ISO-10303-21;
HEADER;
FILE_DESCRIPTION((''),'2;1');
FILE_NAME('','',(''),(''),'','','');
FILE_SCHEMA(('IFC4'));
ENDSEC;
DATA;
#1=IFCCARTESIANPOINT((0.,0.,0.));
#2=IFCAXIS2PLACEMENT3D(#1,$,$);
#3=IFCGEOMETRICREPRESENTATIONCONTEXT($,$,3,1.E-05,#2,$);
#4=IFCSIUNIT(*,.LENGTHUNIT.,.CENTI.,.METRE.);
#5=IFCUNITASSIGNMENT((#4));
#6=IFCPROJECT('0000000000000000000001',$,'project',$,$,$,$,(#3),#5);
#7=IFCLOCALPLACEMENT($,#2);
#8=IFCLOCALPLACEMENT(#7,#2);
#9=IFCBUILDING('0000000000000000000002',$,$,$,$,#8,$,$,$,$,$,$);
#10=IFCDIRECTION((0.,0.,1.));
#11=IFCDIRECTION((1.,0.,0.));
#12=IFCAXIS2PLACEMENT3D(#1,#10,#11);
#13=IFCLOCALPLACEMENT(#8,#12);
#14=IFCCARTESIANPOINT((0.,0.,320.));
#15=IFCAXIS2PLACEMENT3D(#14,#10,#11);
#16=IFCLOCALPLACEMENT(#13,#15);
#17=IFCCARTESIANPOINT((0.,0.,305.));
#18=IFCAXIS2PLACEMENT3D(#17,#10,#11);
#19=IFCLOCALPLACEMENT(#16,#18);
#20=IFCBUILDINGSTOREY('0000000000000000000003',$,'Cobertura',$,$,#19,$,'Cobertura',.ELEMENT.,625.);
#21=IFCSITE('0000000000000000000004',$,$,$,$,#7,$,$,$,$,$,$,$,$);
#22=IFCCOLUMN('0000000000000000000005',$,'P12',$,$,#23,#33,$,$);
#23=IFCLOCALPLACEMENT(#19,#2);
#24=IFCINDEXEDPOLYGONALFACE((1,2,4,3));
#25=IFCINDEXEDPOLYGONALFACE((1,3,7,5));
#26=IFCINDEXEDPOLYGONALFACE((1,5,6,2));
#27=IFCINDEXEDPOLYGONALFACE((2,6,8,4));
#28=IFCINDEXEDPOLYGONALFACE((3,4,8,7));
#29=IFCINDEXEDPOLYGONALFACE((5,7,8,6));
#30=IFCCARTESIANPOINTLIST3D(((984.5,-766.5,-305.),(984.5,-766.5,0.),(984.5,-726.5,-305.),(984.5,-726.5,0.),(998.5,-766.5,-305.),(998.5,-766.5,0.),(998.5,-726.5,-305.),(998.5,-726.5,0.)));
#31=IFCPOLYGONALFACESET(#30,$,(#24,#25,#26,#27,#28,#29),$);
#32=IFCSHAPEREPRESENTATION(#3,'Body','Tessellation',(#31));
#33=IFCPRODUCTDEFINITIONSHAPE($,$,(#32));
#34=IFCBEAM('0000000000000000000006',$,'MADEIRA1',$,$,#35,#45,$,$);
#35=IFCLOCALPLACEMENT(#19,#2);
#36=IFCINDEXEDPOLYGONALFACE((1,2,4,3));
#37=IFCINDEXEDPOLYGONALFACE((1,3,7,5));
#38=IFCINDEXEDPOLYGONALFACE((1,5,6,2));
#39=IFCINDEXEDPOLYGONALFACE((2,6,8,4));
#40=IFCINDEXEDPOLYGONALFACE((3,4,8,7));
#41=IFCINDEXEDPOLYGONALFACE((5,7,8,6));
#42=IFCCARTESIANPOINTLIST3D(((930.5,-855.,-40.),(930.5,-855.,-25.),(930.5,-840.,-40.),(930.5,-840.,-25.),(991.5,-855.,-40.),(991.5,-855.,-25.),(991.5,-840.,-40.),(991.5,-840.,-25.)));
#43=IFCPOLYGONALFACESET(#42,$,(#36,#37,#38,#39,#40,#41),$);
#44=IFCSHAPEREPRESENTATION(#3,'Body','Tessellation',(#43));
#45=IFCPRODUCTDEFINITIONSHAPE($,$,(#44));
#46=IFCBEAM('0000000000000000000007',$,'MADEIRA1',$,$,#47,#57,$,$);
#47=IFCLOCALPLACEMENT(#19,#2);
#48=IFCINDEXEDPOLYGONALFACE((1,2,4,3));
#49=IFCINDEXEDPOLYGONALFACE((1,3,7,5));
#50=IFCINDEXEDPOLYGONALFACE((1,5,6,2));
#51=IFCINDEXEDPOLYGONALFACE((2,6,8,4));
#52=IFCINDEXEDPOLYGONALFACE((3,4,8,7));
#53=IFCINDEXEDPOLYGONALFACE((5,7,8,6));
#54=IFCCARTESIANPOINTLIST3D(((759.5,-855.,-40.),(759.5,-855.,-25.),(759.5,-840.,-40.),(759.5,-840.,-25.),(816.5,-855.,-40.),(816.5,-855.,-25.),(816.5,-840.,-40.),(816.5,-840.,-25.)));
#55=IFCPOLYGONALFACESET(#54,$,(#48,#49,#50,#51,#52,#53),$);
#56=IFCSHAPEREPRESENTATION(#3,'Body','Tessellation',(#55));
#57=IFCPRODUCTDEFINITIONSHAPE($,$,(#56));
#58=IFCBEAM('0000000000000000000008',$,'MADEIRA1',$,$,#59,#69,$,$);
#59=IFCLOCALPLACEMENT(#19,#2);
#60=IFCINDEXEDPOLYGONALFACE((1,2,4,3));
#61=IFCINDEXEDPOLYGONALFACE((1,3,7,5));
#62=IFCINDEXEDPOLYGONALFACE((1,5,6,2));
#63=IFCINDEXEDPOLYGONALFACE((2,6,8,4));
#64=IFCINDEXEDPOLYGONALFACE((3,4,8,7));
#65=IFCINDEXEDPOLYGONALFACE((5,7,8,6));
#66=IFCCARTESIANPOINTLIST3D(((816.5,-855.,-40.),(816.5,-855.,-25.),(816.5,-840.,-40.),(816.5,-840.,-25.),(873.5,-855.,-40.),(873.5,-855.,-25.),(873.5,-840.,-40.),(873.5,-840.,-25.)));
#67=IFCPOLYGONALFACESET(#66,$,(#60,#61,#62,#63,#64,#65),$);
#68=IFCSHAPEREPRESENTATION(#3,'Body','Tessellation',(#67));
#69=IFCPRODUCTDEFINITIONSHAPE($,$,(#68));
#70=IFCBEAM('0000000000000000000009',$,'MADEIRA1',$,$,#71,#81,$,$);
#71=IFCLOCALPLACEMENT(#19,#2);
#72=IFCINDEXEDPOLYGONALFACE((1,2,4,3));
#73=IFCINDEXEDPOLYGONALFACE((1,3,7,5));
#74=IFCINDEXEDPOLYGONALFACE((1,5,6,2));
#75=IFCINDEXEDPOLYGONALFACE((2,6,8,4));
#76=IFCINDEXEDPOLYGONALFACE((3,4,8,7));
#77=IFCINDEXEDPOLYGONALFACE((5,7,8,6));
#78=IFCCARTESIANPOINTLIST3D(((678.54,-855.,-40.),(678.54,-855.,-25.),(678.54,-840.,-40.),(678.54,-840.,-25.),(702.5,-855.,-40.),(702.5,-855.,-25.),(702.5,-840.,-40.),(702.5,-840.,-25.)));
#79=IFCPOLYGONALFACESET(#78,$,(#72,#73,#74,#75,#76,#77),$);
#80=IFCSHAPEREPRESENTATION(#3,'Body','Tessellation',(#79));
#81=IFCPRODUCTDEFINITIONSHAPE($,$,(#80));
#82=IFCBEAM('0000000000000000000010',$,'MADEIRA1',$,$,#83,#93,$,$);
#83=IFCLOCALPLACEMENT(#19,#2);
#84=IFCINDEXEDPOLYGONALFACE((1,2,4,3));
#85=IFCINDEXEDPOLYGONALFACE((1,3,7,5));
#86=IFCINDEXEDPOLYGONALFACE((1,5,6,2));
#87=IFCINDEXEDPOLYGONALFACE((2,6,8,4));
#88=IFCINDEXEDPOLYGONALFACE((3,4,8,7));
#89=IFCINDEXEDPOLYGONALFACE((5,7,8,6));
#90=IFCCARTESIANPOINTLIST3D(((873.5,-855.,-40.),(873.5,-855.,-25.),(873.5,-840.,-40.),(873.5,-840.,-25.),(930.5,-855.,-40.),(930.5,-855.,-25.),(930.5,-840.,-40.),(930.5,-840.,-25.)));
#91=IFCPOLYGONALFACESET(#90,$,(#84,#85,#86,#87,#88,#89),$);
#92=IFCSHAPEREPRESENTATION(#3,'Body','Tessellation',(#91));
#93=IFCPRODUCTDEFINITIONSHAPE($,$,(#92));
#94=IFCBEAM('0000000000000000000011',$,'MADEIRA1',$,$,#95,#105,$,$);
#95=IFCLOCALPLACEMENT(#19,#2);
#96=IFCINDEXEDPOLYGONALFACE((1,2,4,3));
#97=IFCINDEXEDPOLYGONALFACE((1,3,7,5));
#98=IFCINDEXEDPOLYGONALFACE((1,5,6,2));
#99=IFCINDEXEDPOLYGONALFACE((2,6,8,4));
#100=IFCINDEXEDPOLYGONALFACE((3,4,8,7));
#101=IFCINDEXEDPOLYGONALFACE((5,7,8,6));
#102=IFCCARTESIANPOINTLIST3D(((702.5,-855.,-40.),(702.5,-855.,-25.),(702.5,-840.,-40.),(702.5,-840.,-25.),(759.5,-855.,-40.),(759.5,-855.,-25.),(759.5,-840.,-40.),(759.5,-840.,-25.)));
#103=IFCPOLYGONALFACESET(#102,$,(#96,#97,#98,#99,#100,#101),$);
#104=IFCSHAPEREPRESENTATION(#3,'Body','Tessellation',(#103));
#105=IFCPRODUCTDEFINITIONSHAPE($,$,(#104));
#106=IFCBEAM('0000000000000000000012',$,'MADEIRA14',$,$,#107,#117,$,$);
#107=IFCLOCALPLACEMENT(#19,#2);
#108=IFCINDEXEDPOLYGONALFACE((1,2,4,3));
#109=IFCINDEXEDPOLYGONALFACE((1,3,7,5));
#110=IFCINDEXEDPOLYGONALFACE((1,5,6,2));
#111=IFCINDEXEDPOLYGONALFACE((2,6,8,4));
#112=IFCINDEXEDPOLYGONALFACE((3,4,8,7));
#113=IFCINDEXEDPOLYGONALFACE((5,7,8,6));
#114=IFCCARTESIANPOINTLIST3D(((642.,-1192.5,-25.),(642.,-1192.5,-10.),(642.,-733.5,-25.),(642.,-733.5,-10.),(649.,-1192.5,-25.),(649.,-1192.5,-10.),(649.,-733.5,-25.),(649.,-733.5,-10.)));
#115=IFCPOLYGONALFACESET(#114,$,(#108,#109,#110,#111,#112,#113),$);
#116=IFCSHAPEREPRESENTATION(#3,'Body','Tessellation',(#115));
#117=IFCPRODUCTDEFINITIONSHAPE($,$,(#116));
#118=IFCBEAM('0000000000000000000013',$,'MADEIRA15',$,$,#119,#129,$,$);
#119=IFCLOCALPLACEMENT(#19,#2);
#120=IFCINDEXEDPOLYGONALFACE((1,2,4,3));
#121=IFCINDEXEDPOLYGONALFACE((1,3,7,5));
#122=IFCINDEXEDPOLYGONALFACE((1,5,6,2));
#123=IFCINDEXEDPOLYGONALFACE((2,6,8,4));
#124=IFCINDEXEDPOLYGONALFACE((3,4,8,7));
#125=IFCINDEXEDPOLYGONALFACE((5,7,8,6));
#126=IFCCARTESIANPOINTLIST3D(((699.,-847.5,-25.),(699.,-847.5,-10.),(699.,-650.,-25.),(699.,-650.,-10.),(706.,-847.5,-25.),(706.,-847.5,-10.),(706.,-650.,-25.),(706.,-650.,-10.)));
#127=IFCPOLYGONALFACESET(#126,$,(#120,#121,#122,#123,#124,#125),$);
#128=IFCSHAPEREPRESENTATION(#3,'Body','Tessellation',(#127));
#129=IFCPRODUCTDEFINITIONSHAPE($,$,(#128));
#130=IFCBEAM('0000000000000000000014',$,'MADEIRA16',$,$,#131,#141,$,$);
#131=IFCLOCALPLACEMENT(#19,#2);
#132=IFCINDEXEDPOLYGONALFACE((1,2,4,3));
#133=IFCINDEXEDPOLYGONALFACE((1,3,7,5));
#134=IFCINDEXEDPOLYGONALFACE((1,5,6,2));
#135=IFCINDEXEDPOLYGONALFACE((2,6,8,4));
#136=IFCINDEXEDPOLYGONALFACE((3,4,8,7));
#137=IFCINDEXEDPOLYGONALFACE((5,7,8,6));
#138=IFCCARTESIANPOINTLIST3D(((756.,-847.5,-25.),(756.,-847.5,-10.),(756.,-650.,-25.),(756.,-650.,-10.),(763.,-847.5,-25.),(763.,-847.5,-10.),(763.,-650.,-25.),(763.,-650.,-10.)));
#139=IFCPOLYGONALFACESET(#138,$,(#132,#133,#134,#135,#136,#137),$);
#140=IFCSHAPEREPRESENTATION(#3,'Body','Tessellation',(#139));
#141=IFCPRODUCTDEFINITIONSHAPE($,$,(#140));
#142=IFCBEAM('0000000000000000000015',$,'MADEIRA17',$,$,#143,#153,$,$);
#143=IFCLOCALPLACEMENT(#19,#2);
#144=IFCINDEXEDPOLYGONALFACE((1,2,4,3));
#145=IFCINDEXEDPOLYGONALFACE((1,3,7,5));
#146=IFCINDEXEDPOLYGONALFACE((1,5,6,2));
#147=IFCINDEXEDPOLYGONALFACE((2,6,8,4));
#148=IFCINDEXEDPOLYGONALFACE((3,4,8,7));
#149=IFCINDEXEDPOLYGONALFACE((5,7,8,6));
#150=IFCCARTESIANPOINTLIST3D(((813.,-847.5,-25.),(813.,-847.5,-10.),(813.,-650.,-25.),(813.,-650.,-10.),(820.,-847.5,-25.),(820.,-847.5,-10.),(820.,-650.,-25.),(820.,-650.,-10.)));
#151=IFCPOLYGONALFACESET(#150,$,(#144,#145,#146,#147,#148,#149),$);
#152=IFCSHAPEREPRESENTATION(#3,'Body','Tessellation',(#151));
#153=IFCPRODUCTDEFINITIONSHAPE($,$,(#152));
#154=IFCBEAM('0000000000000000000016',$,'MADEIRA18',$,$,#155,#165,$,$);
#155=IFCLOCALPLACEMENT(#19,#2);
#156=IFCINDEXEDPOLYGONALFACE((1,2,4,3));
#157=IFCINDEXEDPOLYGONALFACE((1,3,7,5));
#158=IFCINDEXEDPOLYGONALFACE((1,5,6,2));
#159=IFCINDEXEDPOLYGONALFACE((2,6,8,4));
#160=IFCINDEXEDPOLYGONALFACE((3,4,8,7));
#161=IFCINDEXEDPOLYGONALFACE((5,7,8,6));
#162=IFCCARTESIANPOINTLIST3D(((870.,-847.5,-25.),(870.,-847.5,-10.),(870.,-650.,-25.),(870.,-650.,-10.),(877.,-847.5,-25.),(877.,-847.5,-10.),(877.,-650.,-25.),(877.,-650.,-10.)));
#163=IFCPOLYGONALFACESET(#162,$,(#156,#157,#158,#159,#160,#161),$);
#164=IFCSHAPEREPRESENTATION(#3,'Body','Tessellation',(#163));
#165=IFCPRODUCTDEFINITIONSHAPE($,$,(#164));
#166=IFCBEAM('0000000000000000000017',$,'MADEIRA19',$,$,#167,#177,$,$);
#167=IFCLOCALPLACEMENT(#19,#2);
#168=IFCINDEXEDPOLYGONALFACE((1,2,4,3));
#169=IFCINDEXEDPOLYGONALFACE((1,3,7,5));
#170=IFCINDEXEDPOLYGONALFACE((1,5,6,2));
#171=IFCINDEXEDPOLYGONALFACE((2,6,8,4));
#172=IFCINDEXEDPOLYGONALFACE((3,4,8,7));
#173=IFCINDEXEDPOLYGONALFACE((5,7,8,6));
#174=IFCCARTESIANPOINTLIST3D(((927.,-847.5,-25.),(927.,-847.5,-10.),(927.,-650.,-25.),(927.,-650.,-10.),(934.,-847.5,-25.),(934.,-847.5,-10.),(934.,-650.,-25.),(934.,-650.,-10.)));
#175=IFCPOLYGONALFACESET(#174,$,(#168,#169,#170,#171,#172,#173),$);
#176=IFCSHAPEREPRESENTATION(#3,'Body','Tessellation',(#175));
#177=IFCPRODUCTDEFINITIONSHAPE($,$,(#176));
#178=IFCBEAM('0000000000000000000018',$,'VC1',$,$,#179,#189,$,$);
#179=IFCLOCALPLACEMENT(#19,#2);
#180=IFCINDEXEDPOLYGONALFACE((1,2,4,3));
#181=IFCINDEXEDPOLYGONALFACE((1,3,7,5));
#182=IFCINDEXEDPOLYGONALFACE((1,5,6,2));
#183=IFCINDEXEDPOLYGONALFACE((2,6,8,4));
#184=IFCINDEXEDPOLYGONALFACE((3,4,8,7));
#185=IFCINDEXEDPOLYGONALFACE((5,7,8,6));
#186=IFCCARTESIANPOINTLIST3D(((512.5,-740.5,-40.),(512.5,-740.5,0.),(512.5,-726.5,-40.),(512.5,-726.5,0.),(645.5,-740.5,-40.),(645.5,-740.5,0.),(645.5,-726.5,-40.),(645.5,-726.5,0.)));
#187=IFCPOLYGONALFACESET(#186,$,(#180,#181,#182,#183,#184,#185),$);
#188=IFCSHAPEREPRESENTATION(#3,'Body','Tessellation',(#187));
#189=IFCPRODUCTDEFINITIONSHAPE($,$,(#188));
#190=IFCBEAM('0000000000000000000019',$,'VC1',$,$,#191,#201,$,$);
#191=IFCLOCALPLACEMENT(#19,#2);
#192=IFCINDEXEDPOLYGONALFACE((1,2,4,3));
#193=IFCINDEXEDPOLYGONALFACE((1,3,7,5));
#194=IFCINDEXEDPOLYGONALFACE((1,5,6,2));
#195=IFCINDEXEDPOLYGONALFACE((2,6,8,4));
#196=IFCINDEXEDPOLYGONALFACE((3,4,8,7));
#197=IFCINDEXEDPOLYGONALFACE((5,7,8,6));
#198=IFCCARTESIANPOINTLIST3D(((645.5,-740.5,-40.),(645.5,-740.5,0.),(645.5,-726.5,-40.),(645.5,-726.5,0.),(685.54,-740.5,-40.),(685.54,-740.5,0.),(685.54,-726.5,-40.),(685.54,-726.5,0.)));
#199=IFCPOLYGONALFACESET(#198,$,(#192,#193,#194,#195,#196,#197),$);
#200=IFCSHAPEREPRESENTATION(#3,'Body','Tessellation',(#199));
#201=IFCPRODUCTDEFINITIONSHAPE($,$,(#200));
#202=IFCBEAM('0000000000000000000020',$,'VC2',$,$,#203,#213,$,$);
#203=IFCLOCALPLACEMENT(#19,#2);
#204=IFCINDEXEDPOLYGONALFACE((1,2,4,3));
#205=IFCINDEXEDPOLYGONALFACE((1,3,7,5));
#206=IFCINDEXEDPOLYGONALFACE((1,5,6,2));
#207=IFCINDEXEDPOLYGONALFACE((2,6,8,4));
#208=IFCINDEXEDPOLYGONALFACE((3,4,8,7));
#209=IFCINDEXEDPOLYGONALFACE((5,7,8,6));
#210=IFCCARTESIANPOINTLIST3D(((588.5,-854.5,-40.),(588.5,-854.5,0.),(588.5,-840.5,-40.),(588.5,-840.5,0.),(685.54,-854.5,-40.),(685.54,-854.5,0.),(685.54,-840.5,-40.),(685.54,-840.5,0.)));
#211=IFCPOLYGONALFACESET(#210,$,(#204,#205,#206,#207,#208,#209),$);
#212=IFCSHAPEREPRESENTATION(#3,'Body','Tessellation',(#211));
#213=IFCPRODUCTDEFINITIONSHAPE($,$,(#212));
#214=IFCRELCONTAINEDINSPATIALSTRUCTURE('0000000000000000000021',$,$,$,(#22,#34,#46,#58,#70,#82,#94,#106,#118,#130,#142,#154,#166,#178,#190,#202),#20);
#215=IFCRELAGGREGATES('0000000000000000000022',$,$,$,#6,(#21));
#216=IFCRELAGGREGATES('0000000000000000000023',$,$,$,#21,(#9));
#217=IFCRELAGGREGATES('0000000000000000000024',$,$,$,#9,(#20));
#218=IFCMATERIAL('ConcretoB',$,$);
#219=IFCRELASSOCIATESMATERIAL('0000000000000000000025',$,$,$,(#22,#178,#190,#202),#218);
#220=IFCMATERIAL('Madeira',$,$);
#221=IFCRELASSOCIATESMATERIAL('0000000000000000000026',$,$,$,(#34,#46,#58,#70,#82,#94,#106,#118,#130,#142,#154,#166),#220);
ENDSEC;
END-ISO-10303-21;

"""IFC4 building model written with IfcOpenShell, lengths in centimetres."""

from ifc_helpers import new_model, si_unit, frame, origin, origin_with_axes, place, context, project, spatial, polyline, outline, extrude, material, element, save


model = new_model("IFC4")

# Units and contexts
context_of_model = context(None, 3, precision=1e-05, world=origin())
ifc_project = project(units=[si_unit("LENGTHUNIT", "METRE", prefix="CENTI")], contexts=[context_of_model])

# Site, building, storey
site_placement = place(None, origin())
site = spatial("IfcSite", under=ifc_project, at=site_placement)
building_placement = place(site_placement, origin())
building = spatial("IfcBuilding", under=site, at=building_placement)
placement_1 = place(building_placement, origin_with_axes())
placement_2 = place(placement_1, frame((0.0, 0.0, 320.0), z_axis=(0.0, 0.0, 1.0), x_axis=(1.0, 0.0, 0.0)))
storey_placement = place(placement_2, frame((0.0, 0.0, 305.0), z_axis=(0.0, 0.0, 1.0), x_axis=(1.0, 0.0, 0.0)))
storey = spatial("IfcBuildingStorey", under=building, at=storey_placement, Name="Cobertura", LongName="Cobertura", CompositionType="ELEMENT", Elevation=625.0)

# Column
ifc_material_1 = material(Name="ConcretoB")
column_placement = place(storey_placement, frame((991.5, -746.5, 0.0), z_axis=(0.0, 0.0, 1.0), x_axis=(1.0, 0.0, 0.0)))
element("IfcColumn", 1, at=column_placement, inside=storey, material=ifc_material_1, Name="P12", context=context_of_model, shape_type="SolidModel", body=[
    extrude(outline(polyline([(-7.0, -20.0), (7.0, -20.0), (7.0, 20.0), (-7.0, 20.0), (-7.0, -20.0)])), origin_with_axes(), (0.0, 0.0, -1.0), 305.0),
])

# Beams
ifc_material_2 = material(Name="Madeira")
beam_1_placement = place(storey_placement, frame((961.0, -847.5, -25.0), z_axis=(0.0, 0.0, 1.0), x_axis=(1.0, 0.0, 0.0)))
element("IfcBeam", 2, at=beam_1_placement, inside=storey, material=ifc_material_2, Name="MADEIRA1", context=context_of_model, shape_type="SolidModel", body=[
    extrude(outline(polyline([(-7.5, -7.5), (-7.5, 7.5), (7.5, 7.5), (7.5, -7.5), (-7.5, -7.5)])), frame((-30.5, 0.0, -7.5), z_axis=(1.0, 0.0, 0.0), x_axis=(0.0, -1.0, 0.0)), (0.0, 0.0, 1.0), 61.0),
])
for number, where, z_axis, x_axis, name in (
    (3, (788.0, -847.5, -25.0), (0.0, 0.0, 1.0), (1.0, 0.0, 0.0), "MADEIRA1"),
    (4, (845.0, -847.5, -25.0), (0.0, 0.0, 1.0), (1.0, 0.0, 0.0), "MADEIRA1"),
):
    element("IfcBeam", number, at=place(storey_placement, frame(where, z_axis=z_axis, x_axis=x_axis)), inside=storey, material=ifc_material_2, Name=name, context=context_of_model, shape_type="SolidModel", body=[
        extrude(outline(polyline([(-7.5, -7.5), (-7.5, 7.5), (7.5, 7.5), (7.5, -7.5), (-7.5, -7.5)])), frame((-28.5, 0.0, -7.5), z_axis=(1.0, 0.0, 0.0), x_axis=(0.0, -1.0, 0.0)), (0.0, 0.0, 1.0), 57.0),
    ])
beam_2_placement = place(storey_placement, frame((690.52, -847.5, -25.0), z_axis=(0.0, 0.0, 1.0), x_axis=(1.0, 0.0, 0.0)))
element("IfcBeam", 5, at=beam_2_placement, inside=storey, material=ifc_material_2, Name="MADEIRA1", context=context_of_model, shape_type="SolidModel", body=[
    extrude(outline(polyline([(-7.5, -7.5), (-7.5, 7.5), (7.5, 7.5), (7.5, -7.5), (-7.5, -7.5)])), frame((-11.98, 0.0, -7.5), z_axis=(1.0, 0.0, 0.0), x_axis=(0.0, -1.0, 0.0)), (0.0, 0.0, 1.0), 23.96),
])
for number, where, z_axis, x_axis, name in (
    (6, (902.0, -847.5, -25.0), (0.0, 0.0, 1.0), (1.0, 0.0, 0.0), "MADEIRA1"),
    (7, (731.0, -847.5, -25.0), (0.0, 0.0, 1.0), (1.0, 0.0, 0.0), "MADEIRA1"),
):
    element("IfcBeam", number, at=place(storey_placement, frame(where, z_axis=z_axis, x_axis=x_axis)), inside=storey, material=ifc_material_2, Name=name, context=context_of_model, shape_type="SolidModel", body=[
        extrude(outline(polyline([(-7.5, -7.5), (-7.5, 7.5), (7.5, 7.5), (7.5, -7.5), (-7.5, -7.5)])), frame((-28.5, 0.0, -7.5), z_axis=(1.0, 0.0, 0.0), x_axis=(0.0, -1.0, 0.0)), (0.0, 0.0, 1.0), 57.0),
    ])
beam_3_placement = place(storey_placement, frame((645.5, -963.0, -10.0), z_axis=(0.0, 0.0, 1.0), x_axis=(1.0, 0.0, 0.0)))
element("IfcBeam", 8, at=beam_3_placement, inside=storey, material=ifc_material_2, Name="MADEIRA14", context=context_of_model, shape_type="SolidModel", body=[
    extrude(outline(polyline([(-3.5, -7.5), (-3.5, 7.5), (3.5, 7.5), (3.5, -7.5), (-3.5, -7.5)])), frame((0.0, -229.5, -7.5), z_axis=(0.0, 1.0, 0.0), x_axis=(1.0, 0.0, 0.0)), (0.0, 0.0, 1.0), 459.0),
])
for number, where, z_axis, x_axis, name in (
    (9, (702.5, -748.75, -10.0), (0.0, 0.0, 1.0), (1.0, 0.0, 0.0), "MADEIRA15"),
    (10, (759.5, -748.75, -10.0), (0.0, 0.0, 1.0), (1.0, 0.0, 0.0), "MADEIRA16"),
    (11, (816.5, -748.75, -10.0), (0.0, 0.0, 1.0), (1.0, 0.0, 0.0), "MADEIRA17"),
    (12, (873.5, -748.75, -10.0), (0.0, 0.0, 1.0), (1.0, 0.0, 0.0), "MADEIRA18"),
    (13, (930.5, -748.75, -10.0), (0.0, 0.0, 1.0), (1.0, 0.0, 0.0), "MADEIRA19"),
):
    element("IfcBeam", number, at=place(storey_placement, frame(where, z_axis=z_axis, x_axis=x_axis)), inside=storey, material=ifc_material_2, Name=name, context=context_of_model, shape_type="SolidModel", body=[
        extrude(outline(polyline([(-3.5, -7.5), (-3.5, 7.5), (3.5, 7.5), (3.5, -7.5), (-3.5, -7.5)])), frame((0.0, -98.75, -7.5), z_axis=(0.0, 1.0, 0.0), x_axis=(1.0, 0.0, 0.0)), (0.0, 0.0, 1.0), 197.5),
    ])
beam_4_placement = place(storey_placement, frame((579.0, -733.5, 0.0), z_axis=(0.0, 0.0, 1.0), x_axis=(1.0, 0.0, 0.0)))
element("IfcBeam", 14, at=beam_4_placement, inside=storey, material=ifc_material_1, Name="VC1", context=context_of_model, shape_type="SolidModel", body=[
    extrude(outline(polyline([(-7.0, -20.0), (7.0, -20.0), (7.0, 20.0), (-7.0, 20.0), (-7.0, -20.0)])), frame((-66.5, 0.0, -20.0), z_axis=(1.0, 0.0, 0.0), x_axis=(0.0, -1.0, 0.0)), (0.0, 0.0, 1.0), 133.0),
])
beam_5_placement = place(storey_placement, frame((665.52, -733.5, 0.0), z_axis=(0.0, 0.0, 1.0), x_axis=(1.0, 0.0, 0.0)))
element("IfcBeam", 15, at=beam_5_placement, inside=storey, material=ifc_material_1, Name="VC1", context=context_of_model, shape_type="SolidModel", body=[
    extrude(outline(polyline([(-7.0, -20.0), (7.0, -20.0), (7.0, 20.0), (-7.0, 20.0), (-7.0, -20.0)])), frame((-20.02, 0.0, -20.0), z_axis=(1.0, 0.0, 0.0), x_axis=(0.0, -1.0, 0.0)), (0.0, 0.0, 1.0), 40.04),
])
beam_6_placement = place(storey_placement, frame((637.02, -847.5, 0.0), z_axis=(0.0, 0.0, 1.0), x_axis=(1.0, 0.0, 0.0)))
element("IfcBeam", 16, at=beam_6_placement, inside=storey, material=ifc_material_1, Name="VC2", context=context_of_model, shape_type="SolidModel", body=[
    extrude(outline(polyline([(-7.0, -20.0), (7.0, -20.0), (7.0, 20.0), (-7.0, 20.0), (-7.0, -20.0)])), frame((-48.52, 0.0, -20.0), z_axis=(1.0, 0.0, 0.0), x_axis=(0.0, -1.0, 0.0)), (0.0, 0.0, 1.0), 97.04),
])

save(model, "model.ifc")
